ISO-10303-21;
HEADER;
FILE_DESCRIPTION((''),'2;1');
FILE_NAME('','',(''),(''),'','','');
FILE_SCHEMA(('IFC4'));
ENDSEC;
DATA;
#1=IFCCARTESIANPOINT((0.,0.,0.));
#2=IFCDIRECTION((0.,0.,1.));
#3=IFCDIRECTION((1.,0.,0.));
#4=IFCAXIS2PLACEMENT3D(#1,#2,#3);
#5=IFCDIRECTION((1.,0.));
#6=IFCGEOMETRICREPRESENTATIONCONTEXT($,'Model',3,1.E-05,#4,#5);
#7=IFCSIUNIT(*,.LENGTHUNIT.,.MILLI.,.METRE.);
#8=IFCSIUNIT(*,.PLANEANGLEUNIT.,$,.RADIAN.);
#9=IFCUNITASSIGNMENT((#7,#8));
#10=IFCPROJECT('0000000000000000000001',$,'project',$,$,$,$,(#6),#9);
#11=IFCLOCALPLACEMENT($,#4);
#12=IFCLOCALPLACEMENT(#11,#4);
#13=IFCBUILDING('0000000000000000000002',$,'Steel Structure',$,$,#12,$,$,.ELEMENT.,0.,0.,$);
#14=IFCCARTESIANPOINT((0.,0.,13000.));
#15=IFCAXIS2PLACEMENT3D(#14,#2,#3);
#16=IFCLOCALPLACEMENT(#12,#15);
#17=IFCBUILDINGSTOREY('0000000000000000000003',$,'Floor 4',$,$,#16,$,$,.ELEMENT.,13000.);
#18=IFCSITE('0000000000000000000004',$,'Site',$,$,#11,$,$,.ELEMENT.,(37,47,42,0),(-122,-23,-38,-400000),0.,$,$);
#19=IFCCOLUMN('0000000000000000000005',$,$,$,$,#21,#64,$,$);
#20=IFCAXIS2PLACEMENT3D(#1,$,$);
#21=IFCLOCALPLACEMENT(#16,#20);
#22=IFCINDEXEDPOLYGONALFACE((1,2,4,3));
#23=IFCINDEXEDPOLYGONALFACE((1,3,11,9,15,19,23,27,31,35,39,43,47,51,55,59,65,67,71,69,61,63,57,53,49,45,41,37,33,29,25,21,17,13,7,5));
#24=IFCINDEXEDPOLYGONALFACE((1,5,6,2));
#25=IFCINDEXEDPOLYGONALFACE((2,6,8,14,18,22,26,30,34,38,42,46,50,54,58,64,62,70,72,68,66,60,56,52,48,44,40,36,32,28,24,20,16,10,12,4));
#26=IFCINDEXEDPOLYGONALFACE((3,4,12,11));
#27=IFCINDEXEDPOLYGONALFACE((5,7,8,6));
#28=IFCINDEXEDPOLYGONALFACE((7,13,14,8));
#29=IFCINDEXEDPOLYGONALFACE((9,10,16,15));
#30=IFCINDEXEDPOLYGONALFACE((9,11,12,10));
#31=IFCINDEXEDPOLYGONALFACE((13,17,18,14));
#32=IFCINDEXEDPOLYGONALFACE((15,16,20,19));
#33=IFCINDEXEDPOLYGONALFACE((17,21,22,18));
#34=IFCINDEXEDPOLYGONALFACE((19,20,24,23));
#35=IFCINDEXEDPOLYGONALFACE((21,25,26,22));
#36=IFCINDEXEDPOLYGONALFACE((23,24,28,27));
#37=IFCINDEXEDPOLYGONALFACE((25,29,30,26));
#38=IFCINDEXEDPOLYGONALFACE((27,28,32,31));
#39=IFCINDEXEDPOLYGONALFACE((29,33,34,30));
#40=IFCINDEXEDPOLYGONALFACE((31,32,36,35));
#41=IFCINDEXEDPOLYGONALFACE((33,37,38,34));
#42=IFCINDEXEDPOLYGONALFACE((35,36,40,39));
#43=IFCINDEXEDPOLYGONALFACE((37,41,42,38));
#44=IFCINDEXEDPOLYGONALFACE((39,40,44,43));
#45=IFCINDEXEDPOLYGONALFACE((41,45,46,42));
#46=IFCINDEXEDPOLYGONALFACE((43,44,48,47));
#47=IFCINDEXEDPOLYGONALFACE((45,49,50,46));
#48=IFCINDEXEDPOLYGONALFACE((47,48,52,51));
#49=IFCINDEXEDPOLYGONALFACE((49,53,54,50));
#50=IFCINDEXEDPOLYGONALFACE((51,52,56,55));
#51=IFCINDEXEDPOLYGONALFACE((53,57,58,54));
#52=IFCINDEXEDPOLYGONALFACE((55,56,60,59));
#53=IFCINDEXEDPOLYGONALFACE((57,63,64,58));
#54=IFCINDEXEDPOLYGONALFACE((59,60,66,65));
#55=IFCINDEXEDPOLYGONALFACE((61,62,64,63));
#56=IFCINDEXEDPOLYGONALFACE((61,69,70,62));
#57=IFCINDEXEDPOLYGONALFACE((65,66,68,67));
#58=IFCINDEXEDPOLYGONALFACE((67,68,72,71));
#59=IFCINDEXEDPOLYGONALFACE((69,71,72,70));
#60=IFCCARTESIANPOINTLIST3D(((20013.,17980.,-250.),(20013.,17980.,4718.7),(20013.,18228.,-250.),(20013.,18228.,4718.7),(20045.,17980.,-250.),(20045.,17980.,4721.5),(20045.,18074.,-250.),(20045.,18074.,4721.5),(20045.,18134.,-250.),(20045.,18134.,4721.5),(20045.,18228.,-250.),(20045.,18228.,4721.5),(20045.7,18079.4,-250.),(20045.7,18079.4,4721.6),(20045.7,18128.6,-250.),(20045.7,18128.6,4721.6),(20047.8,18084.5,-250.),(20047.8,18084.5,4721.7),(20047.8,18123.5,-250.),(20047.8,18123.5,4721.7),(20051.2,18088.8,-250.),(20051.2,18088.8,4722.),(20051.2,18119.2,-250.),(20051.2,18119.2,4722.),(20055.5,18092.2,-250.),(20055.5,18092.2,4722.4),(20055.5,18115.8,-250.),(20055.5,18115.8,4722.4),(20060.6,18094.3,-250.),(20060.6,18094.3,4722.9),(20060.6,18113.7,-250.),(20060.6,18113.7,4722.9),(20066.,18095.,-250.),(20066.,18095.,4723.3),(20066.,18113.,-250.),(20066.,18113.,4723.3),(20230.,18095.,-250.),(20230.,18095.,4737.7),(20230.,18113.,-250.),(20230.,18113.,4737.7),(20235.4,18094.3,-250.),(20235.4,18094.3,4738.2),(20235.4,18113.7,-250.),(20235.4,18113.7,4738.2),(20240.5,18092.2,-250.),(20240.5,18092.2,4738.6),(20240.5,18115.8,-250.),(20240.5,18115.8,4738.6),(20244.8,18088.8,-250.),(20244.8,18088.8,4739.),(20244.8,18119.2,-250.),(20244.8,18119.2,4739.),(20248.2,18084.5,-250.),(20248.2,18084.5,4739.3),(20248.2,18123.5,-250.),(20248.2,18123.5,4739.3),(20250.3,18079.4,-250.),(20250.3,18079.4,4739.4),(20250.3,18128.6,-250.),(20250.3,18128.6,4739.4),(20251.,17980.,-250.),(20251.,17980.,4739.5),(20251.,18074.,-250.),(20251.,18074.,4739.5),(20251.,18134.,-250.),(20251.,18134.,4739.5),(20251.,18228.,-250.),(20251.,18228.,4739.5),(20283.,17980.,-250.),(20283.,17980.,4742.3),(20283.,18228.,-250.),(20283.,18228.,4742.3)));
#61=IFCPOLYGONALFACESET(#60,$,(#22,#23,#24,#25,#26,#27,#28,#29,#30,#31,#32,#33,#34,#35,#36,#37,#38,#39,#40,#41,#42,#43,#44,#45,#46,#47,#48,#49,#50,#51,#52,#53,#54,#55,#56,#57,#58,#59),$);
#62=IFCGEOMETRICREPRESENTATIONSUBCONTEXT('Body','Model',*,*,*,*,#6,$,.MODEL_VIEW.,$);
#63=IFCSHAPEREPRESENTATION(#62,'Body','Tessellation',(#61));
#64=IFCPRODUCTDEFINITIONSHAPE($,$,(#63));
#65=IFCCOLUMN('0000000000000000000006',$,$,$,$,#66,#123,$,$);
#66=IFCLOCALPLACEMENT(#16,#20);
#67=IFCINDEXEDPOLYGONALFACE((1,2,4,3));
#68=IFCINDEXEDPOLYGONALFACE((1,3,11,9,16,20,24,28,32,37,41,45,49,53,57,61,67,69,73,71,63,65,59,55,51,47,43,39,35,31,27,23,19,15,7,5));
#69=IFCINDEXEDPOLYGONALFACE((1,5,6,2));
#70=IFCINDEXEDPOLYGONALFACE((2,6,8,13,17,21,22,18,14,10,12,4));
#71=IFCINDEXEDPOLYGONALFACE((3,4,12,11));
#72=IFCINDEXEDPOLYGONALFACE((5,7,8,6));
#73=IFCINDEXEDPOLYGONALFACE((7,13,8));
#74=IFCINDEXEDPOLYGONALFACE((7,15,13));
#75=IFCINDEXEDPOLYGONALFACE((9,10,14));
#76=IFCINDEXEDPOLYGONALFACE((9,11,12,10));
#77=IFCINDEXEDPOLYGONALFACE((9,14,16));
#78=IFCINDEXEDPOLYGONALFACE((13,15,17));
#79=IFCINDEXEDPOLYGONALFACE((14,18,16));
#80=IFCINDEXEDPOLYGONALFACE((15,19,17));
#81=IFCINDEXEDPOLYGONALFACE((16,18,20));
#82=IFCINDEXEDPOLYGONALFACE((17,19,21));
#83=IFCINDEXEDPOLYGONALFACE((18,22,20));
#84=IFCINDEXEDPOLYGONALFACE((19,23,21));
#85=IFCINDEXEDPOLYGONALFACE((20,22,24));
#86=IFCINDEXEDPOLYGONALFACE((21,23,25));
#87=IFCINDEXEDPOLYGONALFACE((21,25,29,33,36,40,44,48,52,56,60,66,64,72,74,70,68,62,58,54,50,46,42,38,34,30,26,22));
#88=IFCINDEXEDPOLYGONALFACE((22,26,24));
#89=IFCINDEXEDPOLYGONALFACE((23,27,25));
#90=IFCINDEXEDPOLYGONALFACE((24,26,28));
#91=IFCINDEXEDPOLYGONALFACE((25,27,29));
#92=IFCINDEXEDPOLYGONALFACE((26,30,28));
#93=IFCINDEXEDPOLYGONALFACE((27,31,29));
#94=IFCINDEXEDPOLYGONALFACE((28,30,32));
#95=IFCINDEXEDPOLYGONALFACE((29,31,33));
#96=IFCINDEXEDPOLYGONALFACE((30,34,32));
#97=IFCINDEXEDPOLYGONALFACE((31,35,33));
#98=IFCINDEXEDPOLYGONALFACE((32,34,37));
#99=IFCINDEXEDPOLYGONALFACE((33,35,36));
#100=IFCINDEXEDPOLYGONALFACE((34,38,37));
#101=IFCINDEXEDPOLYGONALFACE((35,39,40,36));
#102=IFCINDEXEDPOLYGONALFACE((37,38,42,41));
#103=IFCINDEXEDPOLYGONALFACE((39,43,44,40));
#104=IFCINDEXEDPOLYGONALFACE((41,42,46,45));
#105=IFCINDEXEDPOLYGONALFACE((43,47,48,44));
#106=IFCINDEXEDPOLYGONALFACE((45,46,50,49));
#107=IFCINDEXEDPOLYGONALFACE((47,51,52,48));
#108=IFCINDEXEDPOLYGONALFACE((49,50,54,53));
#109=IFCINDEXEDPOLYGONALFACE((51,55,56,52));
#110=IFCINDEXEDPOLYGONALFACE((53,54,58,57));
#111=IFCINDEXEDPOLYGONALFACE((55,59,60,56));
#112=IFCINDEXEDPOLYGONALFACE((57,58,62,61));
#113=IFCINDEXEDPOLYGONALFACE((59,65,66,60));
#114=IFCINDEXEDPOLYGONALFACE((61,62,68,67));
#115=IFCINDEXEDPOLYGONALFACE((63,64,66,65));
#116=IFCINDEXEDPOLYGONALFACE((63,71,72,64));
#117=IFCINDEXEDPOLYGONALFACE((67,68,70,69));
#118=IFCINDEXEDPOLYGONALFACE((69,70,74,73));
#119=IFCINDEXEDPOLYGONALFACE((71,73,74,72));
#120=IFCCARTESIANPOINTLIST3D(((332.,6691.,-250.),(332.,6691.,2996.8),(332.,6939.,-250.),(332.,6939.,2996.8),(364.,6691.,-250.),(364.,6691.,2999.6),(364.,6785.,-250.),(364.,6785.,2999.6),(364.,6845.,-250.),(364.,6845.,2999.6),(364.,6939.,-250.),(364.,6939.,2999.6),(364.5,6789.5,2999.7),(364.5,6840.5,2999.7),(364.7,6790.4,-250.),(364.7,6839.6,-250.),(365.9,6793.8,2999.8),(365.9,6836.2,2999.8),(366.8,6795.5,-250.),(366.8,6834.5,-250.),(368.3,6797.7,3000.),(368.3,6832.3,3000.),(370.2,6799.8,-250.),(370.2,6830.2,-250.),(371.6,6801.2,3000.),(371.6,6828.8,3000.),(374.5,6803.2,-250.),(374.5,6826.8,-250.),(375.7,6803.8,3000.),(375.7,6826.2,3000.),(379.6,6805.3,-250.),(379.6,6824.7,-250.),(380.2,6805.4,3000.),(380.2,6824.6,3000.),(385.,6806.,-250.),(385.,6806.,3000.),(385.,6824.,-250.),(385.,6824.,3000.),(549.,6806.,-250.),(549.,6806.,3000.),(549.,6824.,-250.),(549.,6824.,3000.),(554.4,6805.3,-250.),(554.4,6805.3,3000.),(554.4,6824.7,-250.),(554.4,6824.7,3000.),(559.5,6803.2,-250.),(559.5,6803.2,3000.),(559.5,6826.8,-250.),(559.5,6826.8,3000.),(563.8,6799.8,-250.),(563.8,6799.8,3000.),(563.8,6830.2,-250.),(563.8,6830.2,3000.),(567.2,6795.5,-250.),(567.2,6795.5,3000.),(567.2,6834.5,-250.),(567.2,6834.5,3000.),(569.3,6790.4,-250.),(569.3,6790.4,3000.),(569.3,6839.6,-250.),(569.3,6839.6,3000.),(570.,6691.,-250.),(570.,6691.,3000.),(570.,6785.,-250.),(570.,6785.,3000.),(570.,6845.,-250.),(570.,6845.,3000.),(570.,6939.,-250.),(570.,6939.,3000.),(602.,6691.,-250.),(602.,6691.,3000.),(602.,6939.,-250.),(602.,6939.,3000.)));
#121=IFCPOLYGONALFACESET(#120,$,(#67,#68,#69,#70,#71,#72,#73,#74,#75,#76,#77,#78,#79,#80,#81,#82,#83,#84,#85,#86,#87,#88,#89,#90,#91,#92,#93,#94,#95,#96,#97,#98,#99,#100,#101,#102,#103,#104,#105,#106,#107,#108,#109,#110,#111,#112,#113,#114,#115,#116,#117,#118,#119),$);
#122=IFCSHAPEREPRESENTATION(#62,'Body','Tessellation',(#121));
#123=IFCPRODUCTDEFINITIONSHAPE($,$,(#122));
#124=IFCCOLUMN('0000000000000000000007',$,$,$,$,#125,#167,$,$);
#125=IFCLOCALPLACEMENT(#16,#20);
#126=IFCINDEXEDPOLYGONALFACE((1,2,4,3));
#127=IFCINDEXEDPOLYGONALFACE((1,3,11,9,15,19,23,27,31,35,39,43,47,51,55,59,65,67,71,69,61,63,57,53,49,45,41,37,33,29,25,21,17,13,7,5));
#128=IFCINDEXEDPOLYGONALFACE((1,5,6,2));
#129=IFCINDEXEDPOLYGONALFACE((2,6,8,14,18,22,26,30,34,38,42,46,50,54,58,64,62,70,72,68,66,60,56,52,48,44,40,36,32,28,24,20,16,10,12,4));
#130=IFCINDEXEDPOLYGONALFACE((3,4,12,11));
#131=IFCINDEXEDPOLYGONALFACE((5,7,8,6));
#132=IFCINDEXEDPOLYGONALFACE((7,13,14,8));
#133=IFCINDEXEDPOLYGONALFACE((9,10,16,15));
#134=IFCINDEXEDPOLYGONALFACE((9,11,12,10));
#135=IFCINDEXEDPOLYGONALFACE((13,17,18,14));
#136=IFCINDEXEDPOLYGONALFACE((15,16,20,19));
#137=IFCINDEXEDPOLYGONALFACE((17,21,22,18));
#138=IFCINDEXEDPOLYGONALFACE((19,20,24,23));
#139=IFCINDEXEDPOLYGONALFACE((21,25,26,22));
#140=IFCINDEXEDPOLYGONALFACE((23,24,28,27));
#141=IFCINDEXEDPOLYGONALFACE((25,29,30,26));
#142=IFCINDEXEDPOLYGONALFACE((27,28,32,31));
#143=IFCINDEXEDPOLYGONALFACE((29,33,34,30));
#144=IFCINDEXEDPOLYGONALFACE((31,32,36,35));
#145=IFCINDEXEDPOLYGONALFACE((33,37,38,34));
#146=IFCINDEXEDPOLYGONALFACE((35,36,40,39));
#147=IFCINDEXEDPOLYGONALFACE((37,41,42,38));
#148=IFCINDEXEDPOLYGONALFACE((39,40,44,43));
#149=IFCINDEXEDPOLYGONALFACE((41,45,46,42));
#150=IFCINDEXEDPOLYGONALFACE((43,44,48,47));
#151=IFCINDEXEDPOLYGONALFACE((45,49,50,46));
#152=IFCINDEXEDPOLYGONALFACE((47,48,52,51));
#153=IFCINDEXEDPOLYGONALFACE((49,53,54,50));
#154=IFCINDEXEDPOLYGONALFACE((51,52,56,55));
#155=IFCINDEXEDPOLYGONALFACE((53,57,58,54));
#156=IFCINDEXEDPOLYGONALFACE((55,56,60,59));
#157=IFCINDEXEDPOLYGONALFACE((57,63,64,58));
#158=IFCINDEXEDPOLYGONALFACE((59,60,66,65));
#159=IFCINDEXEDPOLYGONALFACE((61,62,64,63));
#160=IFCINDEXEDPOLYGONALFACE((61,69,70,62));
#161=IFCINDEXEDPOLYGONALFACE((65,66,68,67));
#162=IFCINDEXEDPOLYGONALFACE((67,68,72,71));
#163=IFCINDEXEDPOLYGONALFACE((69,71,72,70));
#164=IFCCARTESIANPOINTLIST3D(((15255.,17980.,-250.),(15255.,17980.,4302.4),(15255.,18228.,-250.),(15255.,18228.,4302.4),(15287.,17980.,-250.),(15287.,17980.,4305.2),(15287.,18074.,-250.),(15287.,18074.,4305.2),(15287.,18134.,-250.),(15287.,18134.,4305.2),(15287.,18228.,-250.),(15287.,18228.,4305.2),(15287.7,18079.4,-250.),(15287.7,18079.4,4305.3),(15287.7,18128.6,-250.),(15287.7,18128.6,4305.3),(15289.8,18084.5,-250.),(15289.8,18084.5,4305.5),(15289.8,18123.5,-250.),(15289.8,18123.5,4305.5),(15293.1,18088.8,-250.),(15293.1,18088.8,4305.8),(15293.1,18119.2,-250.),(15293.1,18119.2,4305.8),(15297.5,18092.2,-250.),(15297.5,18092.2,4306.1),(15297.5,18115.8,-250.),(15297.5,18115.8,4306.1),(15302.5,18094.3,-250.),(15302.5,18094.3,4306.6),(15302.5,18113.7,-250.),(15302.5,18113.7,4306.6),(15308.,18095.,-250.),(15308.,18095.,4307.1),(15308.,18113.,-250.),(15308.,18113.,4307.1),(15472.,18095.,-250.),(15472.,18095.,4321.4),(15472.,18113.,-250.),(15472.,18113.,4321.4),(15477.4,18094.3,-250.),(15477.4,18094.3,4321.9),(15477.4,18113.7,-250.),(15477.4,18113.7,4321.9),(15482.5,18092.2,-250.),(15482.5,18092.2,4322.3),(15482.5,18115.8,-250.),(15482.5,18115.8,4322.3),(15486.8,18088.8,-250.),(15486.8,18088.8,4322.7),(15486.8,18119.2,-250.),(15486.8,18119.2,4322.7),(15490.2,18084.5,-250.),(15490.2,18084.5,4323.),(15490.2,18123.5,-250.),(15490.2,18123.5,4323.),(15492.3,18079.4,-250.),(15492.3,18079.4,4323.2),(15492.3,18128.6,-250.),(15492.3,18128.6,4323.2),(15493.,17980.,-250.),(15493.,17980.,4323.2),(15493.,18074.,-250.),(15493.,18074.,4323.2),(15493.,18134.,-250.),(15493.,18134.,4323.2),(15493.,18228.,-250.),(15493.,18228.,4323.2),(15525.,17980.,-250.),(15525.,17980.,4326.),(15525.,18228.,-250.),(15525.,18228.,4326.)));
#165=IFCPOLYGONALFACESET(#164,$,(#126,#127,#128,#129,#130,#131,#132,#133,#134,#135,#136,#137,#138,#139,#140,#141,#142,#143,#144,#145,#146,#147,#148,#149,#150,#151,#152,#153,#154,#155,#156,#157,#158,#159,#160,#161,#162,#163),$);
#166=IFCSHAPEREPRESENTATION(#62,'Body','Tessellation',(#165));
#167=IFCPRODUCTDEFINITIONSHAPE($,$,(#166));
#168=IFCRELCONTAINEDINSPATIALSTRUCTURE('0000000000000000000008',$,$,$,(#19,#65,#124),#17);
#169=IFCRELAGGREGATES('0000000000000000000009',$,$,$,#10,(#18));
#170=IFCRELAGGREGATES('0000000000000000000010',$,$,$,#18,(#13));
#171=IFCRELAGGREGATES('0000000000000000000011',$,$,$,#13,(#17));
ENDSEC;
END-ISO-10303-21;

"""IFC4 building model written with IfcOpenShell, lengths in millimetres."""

from ifc_helpers import new_model, si_unit, direction, frame, origin_with_axes, origin_2d_with_axis, place, context, subcontext, project, spatial, polyline, i_section, extrude, clip, bounded_halfspace, element, save


model = new_model("IFC4")

# Units and contexts
model_context = context("Model", 3, precision=1e-05, world=origin_with_axes(), true_north=direction((1.0, 0.0)))
body_context = subcontext(model_context, "Body", "Model", "MODEL_VIEW")
ifc_project = project(units=[si_unit("LENGTHUNIT", "METRE", prefix="MILLI"), si_unit("PLANEANGLEUNIT", "RADIAN")], contexts=[model_context])

# Site, building, storey
site_placement = place(None, origin_with_axes())
site = spatial("IfcSite", under=ifc_project, at=site_placement, Name="Site", CompositionType="ELEMENT", RefLatitude=(37, 47, 42, 0), RefLongitude=(-122, -23, -38, -400000), RefElevation=0.0)
building_placement = place(site_placement, origin_with_axes())
building = spatial("IfcBuilding", under=site, at=building_placement, Name="Steel Structure", CompositionType="ELEMENT", ElevationOfRefHeight=0.0, ElevationOfTerrain=0.0)
storey_placement = place(building_placement, frame((0.0, 0.0, 13000.0), z_axis=(0.0, 0.0, 1.0), x_axis=(1.0, 0.0, 0.0)))
storey = spatial("IfcBuildingStorey", under=building, at=storey_placement, Name="Floor 4", CompositionType="ELEMENT", Elevation=13000.0)

# Columns
column_1_placement = place(storey_placement, frame((20148.0, 18104.0, -250.0), z_axis=(0.0, 0.0, 1.0), x_axis=(0.0, -1.0, 0.0)))
element("IfcColumn", 1, at=column_1_placement, inside=storey, context=body_context, shape_type="Clipping", body=[
    clip(extrude(i_section(OverallWidth=248.0, OverallDepth=270.0, WebThickness=18.0, FlangeThickness=32.0, FilletRadius=21.0, at=origin_2d_with_axis()), origin_with_axes(), (0.0, 0.0, 1.0), 4992.3), bounded_halfspace(frame((18104.0, -21534.4, 3096.5), z_axis=(0.0, -0.087156, 0.996195), x_axis=(1.0, 0.0, 0.0)), False, origin_with_axes(), polyline([(124.0, -103.0), (30.0, -103.0), (9.0, -82.0), (9.0, 82.0), (30.0, 103.0), (124.0, 103.0), (124.0, 135.0), (-124.0, 135.0), (-124.0, 103.0), (-30.0, 103.0), (-9.0, 82.0), (-9.0, -82.0), (-30.0, -103.0), (-124.0, -103.0), (-124.0, -135.0), (124.0, -135.0), (124.0, -103.0)]))),
])
column_2_placement = place(storey_placement, frame((467.0, 6815.0, -250.0), z_axis=(0.0, 0.0, 1.0), x_axis=(0.0, -1.0, 0.0)))
element("IfcColumn", 2, at=column_2_placement, inside=storey, context=body_context, shape_type="Clipping", body=[
    clip(extrude(i_section(OverallWidth=248.0, OverallDepth=270.0, WebThickness=18.0, FlangeThickness=32.0, FilletRadius=21.0, at=origin_2d_with_axis()), origin_with_axes(), (0.0, 0.0, 1.0), 3250.0), bounded_halfspace(frame((6815.0, -1853.4, 3096.5), z_axis=(0.0, -0.087156, 0.996195), x_axis=(1.0, 0.0, 0.0)), False, origin_with_axes(), polyline([(-17.3, -98.7), (-30.0, -103.0), (-124.0, -103.0), (-124.0, -135.0), (124.0, -135.0), (124.0, -103.0), (30.0, -103.0), (17.3, -98.7), (-17.3, -98.7)]))),
])
column_3_placement = place(storey_placement, frame((15390.0, 18104.0, -250.0), z_axis=(0.0, 0.0, 1.0), x_axis=(0.0, -1.0, 0.0)))
element("IfcColumn", 3, at=column_3_placement, inside=storey, context=body_context, shape_type="Clipping", body=[
    clip(extrude(i_section(OverallWidth=248.0, OverallDepth=270.0, WebThickness=18.0, FlangeThickness=32.0, FilletRadius=21.0, at=origin_2d_with_axis()), origin_with_axes(), (0.0, 0.0, 1.0), 4576.0), bounded_halfspace(frame((18104.0, -16776.4, 3096.5), z_axis=(0.0, -0.087156, 0.996195), x_axis=(1.0, 0.0, 0.0)), False, origin_with_axes(), polyline([(-124.0, -103.0), (-124.0, -135.0), (124.0, -135.0), (124.0, -103.0), (30.0, -103.0), (9.0, -82.0), (9.0, 82.0), (30.0, 103.0), (124.0, 103.0), (124.0, 135.0), (-124.0, 135.0), (-124.0, 103.0), (-30.0, 103.0), (-9.0, 82.0), (-9.0, -82.0), (-30.0, -103.0), (-124.0, -103.0)]))),
])

save(model, "model.ifc")
